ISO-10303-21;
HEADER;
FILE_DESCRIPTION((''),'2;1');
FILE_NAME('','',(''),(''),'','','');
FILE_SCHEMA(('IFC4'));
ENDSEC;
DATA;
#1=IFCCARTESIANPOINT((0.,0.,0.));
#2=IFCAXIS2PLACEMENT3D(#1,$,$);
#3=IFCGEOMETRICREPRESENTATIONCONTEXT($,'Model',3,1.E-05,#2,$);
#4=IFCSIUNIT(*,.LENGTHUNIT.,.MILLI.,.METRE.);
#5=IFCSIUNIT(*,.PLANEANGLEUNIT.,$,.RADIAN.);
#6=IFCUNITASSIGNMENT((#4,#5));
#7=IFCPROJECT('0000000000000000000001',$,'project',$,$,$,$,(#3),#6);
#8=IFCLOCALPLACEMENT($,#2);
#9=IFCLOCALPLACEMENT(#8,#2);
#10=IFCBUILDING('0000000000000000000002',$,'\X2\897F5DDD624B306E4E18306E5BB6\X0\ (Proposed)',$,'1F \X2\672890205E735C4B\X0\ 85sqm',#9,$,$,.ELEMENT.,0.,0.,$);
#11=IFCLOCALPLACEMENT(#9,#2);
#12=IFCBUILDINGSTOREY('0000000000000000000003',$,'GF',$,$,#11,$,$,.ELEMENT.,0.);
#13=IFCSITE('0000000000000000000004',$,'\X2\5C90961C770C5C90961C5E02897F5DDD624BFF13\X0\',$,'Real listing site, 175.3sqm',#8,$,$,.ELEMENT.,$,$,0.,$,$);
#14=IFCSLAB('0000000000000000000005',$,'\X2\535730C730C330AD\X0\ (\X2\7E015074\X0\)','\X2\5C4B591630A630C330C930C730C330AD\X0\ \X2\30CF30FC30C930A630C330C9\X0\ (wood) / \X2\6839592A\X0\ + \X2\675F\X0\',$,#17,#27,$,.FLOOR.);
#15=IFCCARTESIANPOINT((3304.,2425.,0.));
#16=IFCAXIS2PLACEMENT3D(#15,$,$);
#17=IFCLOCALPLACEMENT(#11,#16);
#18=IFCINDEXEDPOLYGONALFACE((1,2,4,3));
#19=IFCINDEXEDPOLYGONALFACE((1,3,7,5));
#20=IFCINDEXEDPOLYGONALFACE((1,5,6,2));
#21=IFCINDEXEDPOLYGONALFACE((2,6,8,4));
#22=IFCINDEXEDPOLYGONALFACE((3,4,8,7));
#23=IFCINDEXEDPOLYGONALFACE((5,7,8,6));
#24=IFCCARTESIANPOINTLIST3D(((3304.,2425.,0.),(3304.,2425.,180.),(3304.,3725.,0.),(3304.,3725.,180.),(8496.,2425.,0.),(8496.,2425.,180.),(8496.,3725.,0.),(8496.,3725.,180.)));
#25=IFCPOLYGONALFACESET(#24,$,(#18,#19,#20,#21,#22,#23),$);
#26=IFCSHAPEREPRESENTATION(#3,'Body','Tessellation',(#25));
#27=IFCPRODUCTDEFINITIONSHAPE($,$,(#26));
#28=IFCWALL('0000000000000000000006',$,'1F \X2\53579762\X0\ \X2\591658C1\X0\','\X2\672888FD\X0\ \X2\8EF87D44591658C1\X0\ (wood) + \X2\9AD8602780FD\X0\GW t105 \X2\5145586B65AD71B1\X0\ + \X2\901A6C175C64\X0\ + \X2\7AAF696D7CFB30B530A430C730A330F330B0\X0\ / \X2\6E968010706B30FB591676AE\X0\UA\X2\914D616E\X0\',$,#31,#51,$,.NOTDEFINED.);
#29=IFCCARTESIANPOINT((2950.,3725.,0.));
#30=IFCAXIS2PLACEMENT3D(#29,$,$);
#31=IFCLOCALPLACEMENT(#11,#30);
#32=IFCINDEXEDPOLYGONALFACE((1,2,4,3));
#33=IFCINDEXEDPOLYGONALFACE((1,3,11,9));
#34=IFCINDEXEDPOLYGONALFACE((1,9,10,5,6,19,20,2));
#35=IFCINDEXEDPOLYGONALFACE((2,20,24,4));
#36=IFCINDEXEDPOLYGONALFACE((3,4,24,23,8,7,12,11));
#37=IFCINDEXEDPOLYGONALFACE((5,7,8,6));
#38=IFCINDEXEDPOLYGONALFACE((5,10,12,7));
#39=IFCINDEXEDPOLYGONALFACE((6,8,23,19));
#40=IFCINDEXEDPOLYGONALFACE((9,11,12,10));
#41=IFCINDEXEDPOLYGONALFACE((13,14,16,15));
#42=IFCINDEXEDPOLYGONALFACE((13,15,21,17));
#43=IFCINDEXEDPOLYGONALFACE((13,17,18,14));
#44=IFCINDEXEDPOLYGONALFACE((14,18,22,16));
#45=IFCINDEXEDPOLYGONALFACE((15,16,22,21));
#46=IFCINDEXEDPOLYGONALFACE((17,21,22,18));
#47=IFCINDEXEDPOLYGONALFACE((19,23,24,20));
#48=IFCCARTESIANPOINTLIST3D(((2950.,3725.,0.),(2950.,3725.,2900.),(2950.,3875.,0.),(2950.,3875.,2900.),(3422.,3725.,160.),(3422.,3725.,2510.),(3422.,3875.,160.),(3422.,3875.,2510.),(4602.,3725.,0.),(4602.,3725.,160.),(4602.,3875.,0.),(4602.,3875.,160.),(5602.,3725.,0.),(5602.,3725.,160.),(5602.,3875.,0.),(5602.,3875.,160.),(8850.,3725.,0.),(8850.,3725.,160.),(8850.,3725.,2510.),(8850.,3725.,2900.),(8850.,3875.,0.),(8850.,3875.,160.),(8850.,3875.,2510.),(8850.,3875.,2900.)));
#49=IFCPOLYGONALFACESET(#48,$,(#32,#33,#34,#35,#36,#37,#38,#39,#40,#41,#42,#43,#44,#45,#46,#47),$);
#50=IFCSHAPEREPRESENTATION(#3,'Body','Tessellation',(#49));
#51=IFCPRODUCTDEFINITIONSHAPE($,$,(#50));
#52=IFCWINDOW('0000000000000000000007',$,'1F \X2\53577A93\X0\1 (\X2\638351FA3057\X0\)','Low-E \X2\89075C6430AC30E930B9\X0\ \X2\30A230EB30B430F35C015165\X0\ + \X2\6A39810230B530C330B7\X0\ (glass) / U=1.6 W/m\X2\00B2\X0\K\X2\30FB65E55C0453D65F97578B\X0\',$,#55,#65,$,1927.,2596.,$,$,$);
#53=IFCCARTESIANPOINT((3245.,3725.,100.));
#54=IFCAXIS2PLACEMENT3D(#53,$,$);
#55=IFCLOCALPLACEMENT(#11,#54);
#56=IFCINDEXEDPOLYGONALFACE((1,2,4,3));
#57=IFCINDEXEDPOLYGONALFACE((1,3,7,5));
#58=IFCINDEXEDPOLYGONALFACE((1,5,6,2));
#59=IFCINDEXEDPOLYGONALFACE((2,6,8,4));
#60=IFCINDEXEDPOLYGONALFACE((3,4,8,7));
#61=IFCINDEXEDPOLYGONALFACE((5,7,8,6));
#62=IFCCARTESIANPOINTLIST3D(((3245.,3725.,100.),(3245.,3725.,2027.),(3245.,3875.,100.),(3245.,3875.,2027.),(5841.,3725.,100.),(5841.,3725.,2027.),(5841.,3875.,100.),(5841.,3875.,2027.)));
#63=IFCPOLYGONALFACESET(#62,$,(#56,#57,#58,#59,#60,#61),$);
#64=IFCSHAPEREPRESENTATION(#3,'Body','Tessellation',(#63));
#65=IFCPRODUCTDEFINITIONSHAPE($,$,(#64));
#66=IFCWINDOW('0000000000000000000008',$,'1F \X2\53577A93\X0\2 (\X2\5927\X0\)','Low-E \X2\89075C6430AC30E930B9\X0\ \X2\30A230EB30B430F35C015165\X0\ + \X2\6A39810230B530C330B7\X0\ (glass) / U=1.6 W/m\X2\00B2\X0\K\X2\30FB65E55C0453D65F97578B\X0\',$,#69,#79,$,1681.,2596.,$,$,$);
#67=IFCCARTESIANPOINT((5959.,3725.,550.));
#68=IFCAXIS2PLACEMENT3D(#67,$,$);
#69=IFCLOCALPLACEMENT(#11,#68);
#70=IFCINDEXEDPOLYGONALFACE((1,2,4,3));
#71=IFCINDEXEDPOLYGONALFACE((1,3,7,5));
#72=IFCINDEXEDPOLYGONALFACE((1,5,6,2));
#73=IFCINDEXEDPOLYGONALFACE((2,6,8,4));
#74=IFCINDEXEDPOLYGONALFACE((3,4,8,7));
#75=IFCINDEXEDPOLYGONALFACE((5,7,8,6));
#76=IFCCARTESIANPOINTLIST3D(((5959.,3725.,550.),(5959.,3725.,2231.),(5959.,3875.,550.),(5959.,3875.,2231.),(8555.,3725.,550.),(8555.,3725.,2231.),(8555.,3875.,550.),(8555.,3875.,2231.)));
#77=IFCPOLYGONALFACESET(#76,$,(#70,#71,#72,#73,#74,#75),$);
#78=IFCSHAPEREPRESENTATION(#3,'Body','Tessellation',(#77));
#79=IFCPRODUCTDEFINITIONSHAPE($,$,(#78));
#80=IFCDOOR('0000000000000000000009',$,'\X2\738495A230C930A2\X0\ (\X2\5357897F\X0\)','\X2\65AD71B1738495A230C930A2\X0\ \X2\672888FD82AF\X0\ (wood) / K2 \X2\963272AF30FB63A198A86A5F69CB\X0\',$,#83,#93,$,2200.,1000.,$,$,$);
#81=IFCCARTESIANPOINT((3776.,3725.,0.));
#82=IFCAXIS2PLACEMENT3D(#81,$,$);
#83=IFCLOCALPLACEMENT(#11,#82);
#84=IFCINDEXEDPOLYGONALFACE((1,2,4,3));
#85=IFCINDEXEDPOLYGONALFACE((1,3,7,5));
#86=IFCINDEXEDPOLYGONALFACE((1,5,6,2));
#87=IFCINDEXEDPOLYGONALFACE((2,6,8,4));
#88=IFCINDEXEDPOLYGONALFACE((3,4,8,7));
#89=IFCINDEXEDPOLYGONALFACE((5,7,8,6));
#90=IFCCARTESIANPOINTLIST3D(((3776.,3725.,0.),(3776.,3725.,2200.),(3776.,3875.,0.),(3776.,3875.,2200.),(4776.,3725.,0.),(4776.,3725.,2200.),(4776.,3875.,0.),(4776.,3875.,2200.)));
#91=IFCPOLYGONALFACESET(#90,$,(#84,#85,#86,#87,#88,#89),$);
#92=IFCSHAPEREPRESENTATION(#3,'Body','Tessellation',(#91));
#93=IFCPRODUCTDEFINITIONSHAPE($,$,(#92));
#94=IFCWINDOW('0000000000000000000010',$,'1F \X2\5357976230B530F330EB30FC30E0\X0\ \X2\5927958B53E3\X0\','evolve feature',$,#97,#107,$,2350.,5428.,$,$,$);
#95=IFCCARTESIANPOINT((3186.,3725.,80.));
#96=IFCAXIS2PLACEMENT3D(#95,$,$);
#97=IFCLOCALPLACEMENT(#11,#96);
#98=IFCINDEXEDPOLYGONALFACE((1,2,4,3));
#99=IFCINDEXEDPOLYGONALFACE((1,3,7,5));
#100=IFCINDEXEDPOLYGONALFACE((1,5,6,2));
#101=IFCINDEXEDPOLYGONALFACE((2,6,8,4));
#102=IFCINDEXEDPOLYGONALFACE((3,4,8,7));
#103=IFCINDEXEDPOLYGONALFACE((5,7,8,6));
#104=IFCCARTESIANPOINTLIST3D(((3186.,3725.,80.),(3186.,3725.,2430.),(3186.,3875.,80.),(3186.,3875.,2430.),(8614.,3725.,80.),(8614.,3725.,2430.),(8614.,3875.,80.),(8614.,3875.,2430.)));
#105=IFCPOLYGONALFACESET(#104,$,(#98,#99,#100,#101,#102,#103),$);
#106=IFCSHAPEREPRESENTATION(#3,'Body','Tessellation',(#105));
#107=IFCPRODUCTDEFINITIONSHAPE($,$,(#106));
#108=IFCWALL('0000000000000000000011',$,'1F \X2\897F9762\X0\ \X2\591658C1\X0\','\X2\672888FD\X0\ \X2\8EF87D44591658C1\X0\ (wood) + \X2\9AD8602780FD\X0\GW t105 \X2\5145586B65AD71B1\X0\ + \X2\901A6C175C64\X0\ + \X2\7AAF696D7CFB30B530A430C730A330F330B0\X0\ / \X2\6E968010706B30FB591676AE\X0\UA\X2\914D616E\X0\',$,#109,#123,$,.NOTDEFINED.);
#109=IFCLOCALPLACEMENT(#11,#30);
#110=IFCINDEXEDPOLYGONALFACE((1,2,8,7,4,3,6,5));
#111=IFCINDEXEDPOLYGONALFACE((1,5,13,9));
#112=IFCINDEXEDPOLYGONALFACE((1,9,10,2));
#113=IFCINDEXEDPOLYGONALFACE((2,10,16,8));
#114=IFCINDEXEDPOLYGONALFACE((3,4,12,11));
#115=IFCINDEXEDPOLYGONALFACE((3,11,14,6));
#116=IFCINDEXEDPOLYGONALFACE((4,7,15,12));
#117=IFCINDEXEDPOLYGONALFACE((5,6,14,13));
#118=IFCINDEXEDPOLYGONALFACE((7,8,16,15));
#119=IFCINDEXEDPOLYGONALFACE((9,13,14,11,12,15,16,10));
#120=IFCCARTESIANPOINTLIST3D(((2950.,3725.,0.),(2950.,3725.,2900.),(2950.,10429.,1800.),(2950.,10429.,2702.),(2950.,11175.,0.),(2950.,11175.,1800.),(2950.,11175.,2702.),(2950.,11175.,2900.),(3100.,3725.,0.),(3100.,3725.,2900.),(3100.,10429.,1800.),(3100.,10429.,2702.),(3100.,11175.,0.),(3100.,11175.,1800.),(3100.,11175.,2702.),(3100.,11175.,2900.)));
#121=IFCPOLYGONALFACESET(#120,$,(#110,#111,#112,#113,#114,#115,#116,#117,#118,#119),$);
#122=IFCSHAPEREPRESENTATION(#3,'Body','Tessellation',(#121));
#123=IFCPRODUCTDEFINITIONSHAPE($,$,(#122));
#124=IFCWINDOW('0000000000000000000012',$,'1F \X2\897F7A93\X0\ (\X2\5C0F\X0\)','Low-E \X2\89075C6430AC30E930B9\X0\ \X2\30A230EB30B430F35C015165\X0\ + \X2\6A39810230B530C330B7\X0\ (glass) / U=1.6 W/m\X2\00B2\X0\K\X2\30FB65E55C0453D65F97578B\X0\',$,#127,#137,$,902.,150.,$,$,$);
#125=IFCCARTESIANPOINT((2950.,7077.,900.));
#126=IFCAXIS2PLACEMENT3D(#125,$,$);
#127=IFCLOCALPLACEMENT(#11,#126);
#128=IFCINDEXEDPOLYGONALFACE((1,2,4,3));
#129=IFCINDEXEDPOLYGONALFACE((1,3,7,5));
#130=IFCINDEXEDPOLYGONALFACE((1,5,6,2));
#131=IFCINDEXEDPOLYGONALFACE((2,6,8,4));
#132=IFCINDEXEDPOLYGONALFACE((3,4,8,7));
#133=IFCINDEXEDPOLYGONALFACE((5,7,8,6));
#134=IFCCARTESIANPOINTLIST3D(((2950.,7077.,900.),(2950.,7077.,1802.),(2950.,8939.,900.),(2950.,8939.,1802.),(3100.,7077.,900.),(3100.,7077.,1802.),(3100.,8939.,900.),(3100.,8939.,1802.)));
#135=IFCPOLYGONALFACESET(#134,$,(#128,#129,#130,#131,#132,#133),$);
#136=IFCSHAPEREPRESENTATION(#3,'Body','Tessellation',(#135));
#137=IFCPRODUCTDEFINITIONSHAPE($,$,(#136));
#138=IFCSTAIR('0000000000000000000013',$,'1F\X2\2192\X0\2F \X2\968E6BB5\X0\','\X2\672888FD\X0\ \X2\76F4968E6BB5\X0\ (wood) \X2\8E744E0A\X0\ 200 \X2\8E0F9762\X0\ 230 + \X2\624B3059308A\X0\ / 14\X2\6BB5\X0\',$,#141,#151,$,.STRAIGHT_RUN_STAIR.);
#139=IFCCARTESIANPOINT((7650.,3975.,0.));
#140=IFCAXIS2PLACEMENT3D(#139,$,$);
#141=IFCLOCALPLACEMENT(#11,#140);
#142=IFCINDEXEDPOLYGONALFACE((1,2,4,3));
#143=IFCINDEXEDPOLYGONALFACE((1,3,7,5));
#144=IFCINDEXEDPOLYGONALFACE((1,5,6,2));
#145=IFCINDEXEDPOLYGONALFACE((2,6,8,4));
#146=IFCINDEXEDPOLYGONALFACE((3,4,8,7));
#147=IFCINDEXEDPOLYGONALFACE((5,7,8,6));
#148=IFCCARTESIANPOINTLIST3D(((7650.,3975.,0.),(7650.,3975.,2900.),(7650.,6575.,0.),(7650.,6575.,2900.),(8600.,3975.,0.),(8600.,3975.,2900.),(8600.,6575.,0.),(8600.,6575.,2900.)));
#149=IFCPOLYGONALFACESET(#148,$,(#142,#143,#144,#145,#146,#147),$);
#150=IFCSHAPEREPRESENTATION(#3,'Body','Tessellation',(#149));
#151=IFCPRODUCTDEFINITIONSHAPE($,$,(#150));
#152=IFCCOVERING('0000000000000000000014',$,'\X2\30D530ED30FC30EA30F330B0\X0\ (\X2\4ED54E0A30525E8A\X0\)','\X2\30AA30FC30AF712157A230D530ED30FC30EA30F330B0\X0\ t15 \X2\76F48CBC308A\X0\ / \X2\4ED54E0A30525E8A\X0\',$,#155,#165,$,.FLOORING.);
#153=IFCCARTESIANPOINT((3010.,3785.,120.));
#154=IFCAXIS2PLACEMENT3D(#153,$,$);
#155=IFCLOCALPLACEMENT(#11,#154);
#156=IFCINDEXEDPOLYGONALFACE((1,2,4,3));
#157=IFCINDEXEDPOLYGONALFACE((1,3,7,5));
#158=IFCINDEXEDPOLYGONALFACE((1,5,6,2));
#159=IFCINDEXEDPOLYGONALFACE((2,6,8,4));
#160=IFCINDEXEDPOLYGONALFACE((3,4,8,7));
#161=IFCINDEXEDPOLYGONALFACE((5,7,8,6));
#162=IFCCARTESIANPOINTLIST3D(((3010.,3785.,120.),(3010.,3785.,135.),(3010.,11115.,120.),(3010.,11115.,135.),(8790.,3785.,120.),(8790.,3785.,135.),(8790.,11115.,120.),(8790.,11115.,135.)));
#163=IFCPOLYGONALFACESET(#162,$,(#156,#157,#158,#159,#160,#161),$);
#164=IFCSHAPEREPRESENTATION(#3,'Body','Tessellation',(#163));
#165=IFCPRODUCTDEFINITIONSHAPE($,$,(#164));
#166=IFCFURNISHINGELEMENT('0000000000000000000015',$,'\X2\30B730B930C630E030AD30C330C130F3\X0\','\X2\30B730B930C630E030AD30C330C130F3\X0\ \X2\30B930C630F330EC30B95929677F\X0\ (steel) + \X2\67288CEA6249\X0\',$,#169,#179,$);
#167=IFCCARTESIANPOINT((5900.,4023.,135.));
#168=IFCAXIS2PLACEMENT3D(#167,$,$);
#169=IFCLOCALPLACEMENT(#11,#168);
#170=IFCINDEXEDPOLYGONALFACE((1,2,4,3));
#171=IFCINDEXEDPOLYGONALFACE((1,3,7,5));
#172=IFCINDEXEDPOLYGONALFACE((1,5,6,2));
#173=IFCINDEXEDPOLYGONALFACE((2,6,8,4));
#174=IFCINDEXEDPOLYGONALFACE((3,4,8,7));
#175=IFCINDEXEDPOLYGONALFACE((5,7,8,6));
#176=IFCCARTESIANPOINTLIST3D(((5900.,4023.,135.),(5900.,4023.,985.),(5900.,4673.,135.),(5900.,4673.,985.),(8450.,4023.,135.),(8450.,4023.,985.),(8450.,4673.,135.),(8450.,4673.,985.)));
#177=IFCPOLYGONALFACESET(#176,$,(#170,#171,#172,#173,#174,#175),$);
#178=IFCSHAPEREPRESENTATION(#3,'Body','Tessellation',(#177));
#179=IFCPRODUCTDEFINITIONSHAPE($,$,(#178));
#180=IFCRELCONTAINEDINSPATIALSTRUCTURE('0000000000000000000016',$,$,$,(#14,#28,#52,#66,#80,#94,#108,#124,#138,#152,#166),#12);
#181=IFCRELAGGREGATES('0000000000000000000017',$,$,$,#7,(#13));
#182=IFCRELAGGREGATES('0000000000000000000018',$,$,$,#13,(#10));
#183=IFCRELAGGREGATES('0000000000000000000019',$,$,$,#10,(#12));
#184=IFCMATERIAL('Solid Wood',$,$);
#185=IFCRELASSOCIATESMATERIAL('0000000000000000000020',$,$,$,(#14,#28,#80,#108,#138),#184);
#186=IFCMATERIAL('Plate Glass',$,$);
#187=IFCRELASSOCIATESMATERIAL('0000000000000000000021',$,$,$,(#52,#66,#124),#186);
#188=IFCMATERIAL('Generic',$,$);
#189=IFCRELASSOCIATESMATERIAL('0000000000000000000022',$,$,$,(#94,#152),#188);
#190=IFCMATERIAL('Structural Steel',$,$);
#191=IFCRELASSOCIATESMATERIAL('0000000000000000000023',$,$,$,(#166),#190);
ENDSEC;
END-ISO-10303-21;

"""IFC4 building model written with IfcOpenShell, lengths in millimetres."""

from ifc_helpers import new_model, si_unit, frame, frame_2d, origin, place, context, project, spatial, rectangle, extrude, material, element, fill, save


model = new_model("IFC4")

# Units and contexts
model_context = context("Model", 3, precision=1e-05, world=origin())
ifc_project = project(units=[si_unit("LENGTHUNIT", "METRE", prefix="MILLI"), si_unit("PLANEANGLEUNIT", "RADIAN")], contexts=[model_context])

# Site, building, storey
site_placement = place(None, origin())
site = spatial("IfcSite", under=ifc_project, at=site_placement, Name="岐阜県岐阜市西川手３", ObjectType="Real listing site, 175.3sqm", CompositionType="ELEMENT", RefElevation=0.0)
building_placement = place(site_placement, origin())
building = spatial("IfcBuilding", under=site, at=building_placement, Name="西川手の丘の家 (Proposed)", ObjectType="1F 木造平屋 85sqm", CompositionType="ELEMENT", ElevationOfRefHeight=0.0, ElevationOfTerrain=0.0)
storey_placement = place(building_placement, origin())
storey = spatial("IfcBuildingStorey", under=building, at=storey_placement, Name="GF", CompositionType="ELEMENT", Elevation=0.0)

# Slab
ifc_material_1 = material(Name="Solid Wood")
slab_1_placement = place(storey_placement, frame((3304.0, 2425.0, 0.0)))
element("IfcSlab", 1, at=slab_1_placement, inside=storey, material=ifc_material_1, Name="南デッキ (縁側)", Description="屋外ウッドデッキ ハードウッド (wood) / 根太 + 束", PredefinedType="FLOOR", context=model_context, shape_type="SweptSolid", body=[
    extrude(rectangle(XDim=5192.0, YDim=1300.0, at=frame_2d((2596.0, 650.0))), frame((3304.0, 2425.0, 0.0)), (0.0, 0.0, 1.0), 180.0),
])
ifc_material_2 = material(Name="Generic")

# Wall, openings, windows, door
wall_1_placement = place(storey_placement, frame((2950.0, 3725.0, 0.0)))
wall_1 = element("IfcWall", 2, at=wall_1_placement, inside=storey, material=ifc_material_1, Name="1F 南面 外壁", Description="木製 軸組外壁 (wood) + 高性能GW t105 充填断熱 + 通気層 + 窯業系サイディング / 準耐火・外皮UA配慮", PredefinedType="NOTDEFINED", context=model_context, shape_type="SweptSolid", body=[
    extrude(rectangle(XDim=5900.0, YDim=150.0, at=frame_2d((2950.0, 75.0))), frame((2950.0, 3725.0, 0.0)), (0.0, 0.0, 1.0), 2900.0),
])
opening_1_placement = place(storey_placement, frame((3245.0, 3725.0, 100.0)))
opening_1 = element("IfcOpeningElement", 3, at=opening_1_placement, cuts=wall_1, PredefinedType="NOTDEFINED", context=model_context, shape_type="SweptSolid", body=[
    extrude(rectangle(XDim=2596.0, YDim=150.0, at=frame_2d((1298.0, 75.0))), frame((3245.0, 3725.0, 100.0)), (0.0, 0.0, 1.0), 1927.0),
])
opening_2_placement = place(storey_placement, frame((5959.0, 3725.0, 550.0)))
opening_2 = element("IfcOpeningElement", 4, at=opening_2_placement, cuts=wall_1, PredefinedType="NOTDEFINED", context=model_context, shape_type="SweptSolid", body=[
    extrude(rectangle(XDim=2596.0, YDim=150.0, at=frame_2d((1298.0, 75.0))), frame((5959.0, 3725.0, 550.0)), (0.0, 0.0, 1.0), 1681.0),
])
opening_3_placement = place(storey_placement, frame((3776.0, 3725.0, 0.0)))
opening_3 = element("IfcOpeningElement", 5, at=opening_3_placement, cuts=wall_1, PredefinedType="NOTDEFINED", context=model_context, shape_type="SweptSolid", body=[
    extrude(rectangle(XDim=1000.0, YDim=150.0, at=frame_2d((500.0, 75.0))), frame((3776.0, 3725.0, 0.0)), (0.0, 0.0, 1.0), 2200.0),
])
opening_4_placement = place(storey_placement, frame((3186.0, 3725.0, 80.0)))
opening_4 = element("IfcOpeningElement", 6, at=opening_4_placement, cuts=wall_1, PredefinedType="NOTDEFINED", context=model_context, shape_type="SweptSolid", body=[
    extrude(rectangle(XDim=5428.0, YDim=150.0, at=frame_2d((2714.0, 75.0))), frame((3186.0, 3725.0, 80.0)), (0.0, 0.0, 1.0), 2350.0),
])
ifc_material_3 = material(Name="Plate Glass")
window_1_placement = place(storey_placement, frame((3245.0, 3725.0, 100.0)))
window_1 = element("IfcWindow", 7, at=window_1_placement, inside=storey, material=ifc_material_3, Name="1F 南窓1 (掃出し)", Description="Low-E 複層ガラス アルゴン封入 + 樹脂サッシ (glass) / U=1.6 W/m²K・日射取得型", OverallHeight=1927.0, OverallWidth=2596.0, context=model_context, shape_type="SweptSolid", body=[
    extrude(rectangle(XDim=2596.0, YDim=150.0, at=frame_2d((1298.0, 75.0))), frame((3245.0, 3725.0, 100.0)), (0.0, 0.0, 1.0), 1927.0),
])
fill(opening_1, window_1)
window_2_placement = place(storey_placement, frame((5959.0, 3725.0, 550.0)))
window_2 = element("IfcWindow", 8, at=window_2_placement, inside=storey, material=ifc_material_3, Name="1F 南窓2 (大)", Description="Low-E 複層ガラス アルゴン封入 + 樹脂サッシ (glass) / U=1.6 W/m²K・日射取得型", OverallHeight=1681.0, OverallWidth=2596.0, context=model_context, shape_type="SweptSolid", body=[
    extrude(rectangle(XDim=2596.0, YDim=150.0, at=frame_2d((1298.0, 75.0))), frame((5959.0, 3725.0, 550.0)), (0.0, 0.0, 1.0), 1681.0),
])
fill(opening_2, window_2)
door_placement = place(storey_placement, frame((3776.0, 3725.0, 0.0)))
door = element("IfcDoor", 9, at=door_placement, inside=storey, material=ifc_material_1, Name="玄関ドア (南西)", Description="断熱玄関ドア 木製芯 (wood) / K2 防犯・採風機構", OverallHeight=2200.0, OverallWidth=1000.0, context=model_context, shape_type="SweptSolid", body=[
    extrude(rectangle(XDim=1000.0, YDim=150.0, at=frame_2d((500.0, 75.0))), frame((3776.0, 3725.0, 0.0)), (0.0, 0.0, 1.0), 2200.0),
])
fill(opening_3, door)
window_3_placement = place(storey_placement, frame((3186.0, 3725.0, 80.0)))
window_3 = element("IfcWindow", 10, at=window_3_placement, inside=storey, material=ifc_material_2, Name="1F 南面サンルーム 大開口", Description="evolve feature", OverallHeight=2350.0, OverallWidth=5428.0, context=model_context, shape_type="SweptSolid", body=[
    extrude(rectangle(XDim=5428.0, YDim=150.0, at=frame_2d((2714.0, 75.0))), frame((3186.0, 3725.0, 80.0)), (0.0, 0.0, 1.0), 2350.0),
])
fill(opening_4, window_3)

# Wall, opening, window
wall_2_placement = place(storey_placement, frame((2950.0, 3725.0, 0.0)))
wall_2 = element("IfcWall", 11, at=wall_2_placement, inside=storey, material=ifc_material_1, Name="1F 西面 外壁", Description="木製 軸組外壁 (wood) + 高性能GW t105 充填断熱 + 通気層 + 窯業系サイディング / 準耐火・外皮UA配慮", PredefinedType="NOTDEFINED", context=model_context, shape_type="SweptSolid", body=[
    extrude(rectangle(XDim=150.0, YDim=7450.0, at=frame_2d((75.0, 3725.0))), frame((2950.0, 3725.0, 0.0)), (0.0, 0.0, 1.0), 2900.0),
])
opening_5_placement = place(storey_placement, frame((2950.0, 7077.0, 900.0)))
opening_5 = element("IfcOpeningElement", 12, at=opening_5_placement, cuts=wall_2, PredefinedType="NOTDEFINED", context=model_context, shape_type="SweptSolid", body=[
    extrude(rectangle(XDim=150.0, YDim=1862.0, at=frame_2d((75.0, 931.0))), frame((2950.0, 7077.0, 900.0)), (0.0, 0.0, 1.0), 902.0),
])
window_4_placement = place(storey_placement, frame((2950.0, 7077.0, 900.0)))
window_4 = element("IfcWindow", 13, at=window_4_placement, inside=storey, material=ifc_material_3, Name="1F 西窓 (小)", Description="Low-E 複層ガラス アルゴン封入 + 樹脂サッシ (glass) / U=1.6 W/m²K・日射取得型", OverallHeight=902.0, OverallWidth=150.0, context=model_context, shape_type="SweptSolid", body=[
    extrude(rectangle(XDim=150.0, YDim=1862.0, at=frame_2d((75.0, 931.0))), frame((2950.0, 7077.0, 900.0)), (0.0, 0.0, 1.0), 902.0),
])
fill(opening_5, window_4)

# Stair
stair_placement = place(storey_placement, frame((7650.0, 3975.0, 0.0)))
element("IfcStair", 14, at=stair_placement, inside=storey, material=ifc_material_1, Name="1F→2F 階段", Description="木製 直階段 (wood) 蹴上 200 踏面 230 + 手すり / 14段", PredefinedType="STRAIGHT_RUN_STAIR", context=model_context, shape_type="SweptSolid", body=[
    extrude(rectangle(XDim=950.0, YDim=2600.0, at=frame_2d((475.0, 1300.0))), frame((7650.0, 3975.0, 0.0)), (0.0, 0.0, 1.0), 2900.0),
])

# Covering
covering_placement = place(storey_placement, frame((3010.0, 3785.0, 120.0)))
element("IfcCovering", 15, at=covering_placement, inside=storey, material=ifc_material_2, Name="フローリング (仕上げ床)", Description="オーク無垢フローリング t15 直貼り / 仕上げ床", PredefinedType="FLOORING", context=model_context, shape_type="SweptSolid", body=[
    extrude(rectangle(XDim=5780.0, YDim=7330.0, at=frame_2d((2890.0, 3665.0))), frame((3010.0, 3785.0, 120.0)), (0.0, 0.0, 1.0), 15.0),
])

# Furnishing element
ifc_material_4 = material(Name="Structural Steel")
furnishing_placement = place(storey_placement, frame((5900.0, 4023.0, 135.0)))
element("IfcFurnishingElement", 16, at=furnishing_placement, inside=storey, material=ifc_material_4, Name="システムキッチン", Description="システムキッチン ステンレス天板 (steel) + 木質扉", context=model_context, shape_type="SweptSolid", body=[
    extrude(rectangle(XDim=2550.0, YDim=650.0, at=frame_2d((1275.0, 325.0))), frame((5900.0, 4023.0, 135.0)), (0.0, 0.0, 1.0), 850.0),
])

save(model, "model.ifc")
